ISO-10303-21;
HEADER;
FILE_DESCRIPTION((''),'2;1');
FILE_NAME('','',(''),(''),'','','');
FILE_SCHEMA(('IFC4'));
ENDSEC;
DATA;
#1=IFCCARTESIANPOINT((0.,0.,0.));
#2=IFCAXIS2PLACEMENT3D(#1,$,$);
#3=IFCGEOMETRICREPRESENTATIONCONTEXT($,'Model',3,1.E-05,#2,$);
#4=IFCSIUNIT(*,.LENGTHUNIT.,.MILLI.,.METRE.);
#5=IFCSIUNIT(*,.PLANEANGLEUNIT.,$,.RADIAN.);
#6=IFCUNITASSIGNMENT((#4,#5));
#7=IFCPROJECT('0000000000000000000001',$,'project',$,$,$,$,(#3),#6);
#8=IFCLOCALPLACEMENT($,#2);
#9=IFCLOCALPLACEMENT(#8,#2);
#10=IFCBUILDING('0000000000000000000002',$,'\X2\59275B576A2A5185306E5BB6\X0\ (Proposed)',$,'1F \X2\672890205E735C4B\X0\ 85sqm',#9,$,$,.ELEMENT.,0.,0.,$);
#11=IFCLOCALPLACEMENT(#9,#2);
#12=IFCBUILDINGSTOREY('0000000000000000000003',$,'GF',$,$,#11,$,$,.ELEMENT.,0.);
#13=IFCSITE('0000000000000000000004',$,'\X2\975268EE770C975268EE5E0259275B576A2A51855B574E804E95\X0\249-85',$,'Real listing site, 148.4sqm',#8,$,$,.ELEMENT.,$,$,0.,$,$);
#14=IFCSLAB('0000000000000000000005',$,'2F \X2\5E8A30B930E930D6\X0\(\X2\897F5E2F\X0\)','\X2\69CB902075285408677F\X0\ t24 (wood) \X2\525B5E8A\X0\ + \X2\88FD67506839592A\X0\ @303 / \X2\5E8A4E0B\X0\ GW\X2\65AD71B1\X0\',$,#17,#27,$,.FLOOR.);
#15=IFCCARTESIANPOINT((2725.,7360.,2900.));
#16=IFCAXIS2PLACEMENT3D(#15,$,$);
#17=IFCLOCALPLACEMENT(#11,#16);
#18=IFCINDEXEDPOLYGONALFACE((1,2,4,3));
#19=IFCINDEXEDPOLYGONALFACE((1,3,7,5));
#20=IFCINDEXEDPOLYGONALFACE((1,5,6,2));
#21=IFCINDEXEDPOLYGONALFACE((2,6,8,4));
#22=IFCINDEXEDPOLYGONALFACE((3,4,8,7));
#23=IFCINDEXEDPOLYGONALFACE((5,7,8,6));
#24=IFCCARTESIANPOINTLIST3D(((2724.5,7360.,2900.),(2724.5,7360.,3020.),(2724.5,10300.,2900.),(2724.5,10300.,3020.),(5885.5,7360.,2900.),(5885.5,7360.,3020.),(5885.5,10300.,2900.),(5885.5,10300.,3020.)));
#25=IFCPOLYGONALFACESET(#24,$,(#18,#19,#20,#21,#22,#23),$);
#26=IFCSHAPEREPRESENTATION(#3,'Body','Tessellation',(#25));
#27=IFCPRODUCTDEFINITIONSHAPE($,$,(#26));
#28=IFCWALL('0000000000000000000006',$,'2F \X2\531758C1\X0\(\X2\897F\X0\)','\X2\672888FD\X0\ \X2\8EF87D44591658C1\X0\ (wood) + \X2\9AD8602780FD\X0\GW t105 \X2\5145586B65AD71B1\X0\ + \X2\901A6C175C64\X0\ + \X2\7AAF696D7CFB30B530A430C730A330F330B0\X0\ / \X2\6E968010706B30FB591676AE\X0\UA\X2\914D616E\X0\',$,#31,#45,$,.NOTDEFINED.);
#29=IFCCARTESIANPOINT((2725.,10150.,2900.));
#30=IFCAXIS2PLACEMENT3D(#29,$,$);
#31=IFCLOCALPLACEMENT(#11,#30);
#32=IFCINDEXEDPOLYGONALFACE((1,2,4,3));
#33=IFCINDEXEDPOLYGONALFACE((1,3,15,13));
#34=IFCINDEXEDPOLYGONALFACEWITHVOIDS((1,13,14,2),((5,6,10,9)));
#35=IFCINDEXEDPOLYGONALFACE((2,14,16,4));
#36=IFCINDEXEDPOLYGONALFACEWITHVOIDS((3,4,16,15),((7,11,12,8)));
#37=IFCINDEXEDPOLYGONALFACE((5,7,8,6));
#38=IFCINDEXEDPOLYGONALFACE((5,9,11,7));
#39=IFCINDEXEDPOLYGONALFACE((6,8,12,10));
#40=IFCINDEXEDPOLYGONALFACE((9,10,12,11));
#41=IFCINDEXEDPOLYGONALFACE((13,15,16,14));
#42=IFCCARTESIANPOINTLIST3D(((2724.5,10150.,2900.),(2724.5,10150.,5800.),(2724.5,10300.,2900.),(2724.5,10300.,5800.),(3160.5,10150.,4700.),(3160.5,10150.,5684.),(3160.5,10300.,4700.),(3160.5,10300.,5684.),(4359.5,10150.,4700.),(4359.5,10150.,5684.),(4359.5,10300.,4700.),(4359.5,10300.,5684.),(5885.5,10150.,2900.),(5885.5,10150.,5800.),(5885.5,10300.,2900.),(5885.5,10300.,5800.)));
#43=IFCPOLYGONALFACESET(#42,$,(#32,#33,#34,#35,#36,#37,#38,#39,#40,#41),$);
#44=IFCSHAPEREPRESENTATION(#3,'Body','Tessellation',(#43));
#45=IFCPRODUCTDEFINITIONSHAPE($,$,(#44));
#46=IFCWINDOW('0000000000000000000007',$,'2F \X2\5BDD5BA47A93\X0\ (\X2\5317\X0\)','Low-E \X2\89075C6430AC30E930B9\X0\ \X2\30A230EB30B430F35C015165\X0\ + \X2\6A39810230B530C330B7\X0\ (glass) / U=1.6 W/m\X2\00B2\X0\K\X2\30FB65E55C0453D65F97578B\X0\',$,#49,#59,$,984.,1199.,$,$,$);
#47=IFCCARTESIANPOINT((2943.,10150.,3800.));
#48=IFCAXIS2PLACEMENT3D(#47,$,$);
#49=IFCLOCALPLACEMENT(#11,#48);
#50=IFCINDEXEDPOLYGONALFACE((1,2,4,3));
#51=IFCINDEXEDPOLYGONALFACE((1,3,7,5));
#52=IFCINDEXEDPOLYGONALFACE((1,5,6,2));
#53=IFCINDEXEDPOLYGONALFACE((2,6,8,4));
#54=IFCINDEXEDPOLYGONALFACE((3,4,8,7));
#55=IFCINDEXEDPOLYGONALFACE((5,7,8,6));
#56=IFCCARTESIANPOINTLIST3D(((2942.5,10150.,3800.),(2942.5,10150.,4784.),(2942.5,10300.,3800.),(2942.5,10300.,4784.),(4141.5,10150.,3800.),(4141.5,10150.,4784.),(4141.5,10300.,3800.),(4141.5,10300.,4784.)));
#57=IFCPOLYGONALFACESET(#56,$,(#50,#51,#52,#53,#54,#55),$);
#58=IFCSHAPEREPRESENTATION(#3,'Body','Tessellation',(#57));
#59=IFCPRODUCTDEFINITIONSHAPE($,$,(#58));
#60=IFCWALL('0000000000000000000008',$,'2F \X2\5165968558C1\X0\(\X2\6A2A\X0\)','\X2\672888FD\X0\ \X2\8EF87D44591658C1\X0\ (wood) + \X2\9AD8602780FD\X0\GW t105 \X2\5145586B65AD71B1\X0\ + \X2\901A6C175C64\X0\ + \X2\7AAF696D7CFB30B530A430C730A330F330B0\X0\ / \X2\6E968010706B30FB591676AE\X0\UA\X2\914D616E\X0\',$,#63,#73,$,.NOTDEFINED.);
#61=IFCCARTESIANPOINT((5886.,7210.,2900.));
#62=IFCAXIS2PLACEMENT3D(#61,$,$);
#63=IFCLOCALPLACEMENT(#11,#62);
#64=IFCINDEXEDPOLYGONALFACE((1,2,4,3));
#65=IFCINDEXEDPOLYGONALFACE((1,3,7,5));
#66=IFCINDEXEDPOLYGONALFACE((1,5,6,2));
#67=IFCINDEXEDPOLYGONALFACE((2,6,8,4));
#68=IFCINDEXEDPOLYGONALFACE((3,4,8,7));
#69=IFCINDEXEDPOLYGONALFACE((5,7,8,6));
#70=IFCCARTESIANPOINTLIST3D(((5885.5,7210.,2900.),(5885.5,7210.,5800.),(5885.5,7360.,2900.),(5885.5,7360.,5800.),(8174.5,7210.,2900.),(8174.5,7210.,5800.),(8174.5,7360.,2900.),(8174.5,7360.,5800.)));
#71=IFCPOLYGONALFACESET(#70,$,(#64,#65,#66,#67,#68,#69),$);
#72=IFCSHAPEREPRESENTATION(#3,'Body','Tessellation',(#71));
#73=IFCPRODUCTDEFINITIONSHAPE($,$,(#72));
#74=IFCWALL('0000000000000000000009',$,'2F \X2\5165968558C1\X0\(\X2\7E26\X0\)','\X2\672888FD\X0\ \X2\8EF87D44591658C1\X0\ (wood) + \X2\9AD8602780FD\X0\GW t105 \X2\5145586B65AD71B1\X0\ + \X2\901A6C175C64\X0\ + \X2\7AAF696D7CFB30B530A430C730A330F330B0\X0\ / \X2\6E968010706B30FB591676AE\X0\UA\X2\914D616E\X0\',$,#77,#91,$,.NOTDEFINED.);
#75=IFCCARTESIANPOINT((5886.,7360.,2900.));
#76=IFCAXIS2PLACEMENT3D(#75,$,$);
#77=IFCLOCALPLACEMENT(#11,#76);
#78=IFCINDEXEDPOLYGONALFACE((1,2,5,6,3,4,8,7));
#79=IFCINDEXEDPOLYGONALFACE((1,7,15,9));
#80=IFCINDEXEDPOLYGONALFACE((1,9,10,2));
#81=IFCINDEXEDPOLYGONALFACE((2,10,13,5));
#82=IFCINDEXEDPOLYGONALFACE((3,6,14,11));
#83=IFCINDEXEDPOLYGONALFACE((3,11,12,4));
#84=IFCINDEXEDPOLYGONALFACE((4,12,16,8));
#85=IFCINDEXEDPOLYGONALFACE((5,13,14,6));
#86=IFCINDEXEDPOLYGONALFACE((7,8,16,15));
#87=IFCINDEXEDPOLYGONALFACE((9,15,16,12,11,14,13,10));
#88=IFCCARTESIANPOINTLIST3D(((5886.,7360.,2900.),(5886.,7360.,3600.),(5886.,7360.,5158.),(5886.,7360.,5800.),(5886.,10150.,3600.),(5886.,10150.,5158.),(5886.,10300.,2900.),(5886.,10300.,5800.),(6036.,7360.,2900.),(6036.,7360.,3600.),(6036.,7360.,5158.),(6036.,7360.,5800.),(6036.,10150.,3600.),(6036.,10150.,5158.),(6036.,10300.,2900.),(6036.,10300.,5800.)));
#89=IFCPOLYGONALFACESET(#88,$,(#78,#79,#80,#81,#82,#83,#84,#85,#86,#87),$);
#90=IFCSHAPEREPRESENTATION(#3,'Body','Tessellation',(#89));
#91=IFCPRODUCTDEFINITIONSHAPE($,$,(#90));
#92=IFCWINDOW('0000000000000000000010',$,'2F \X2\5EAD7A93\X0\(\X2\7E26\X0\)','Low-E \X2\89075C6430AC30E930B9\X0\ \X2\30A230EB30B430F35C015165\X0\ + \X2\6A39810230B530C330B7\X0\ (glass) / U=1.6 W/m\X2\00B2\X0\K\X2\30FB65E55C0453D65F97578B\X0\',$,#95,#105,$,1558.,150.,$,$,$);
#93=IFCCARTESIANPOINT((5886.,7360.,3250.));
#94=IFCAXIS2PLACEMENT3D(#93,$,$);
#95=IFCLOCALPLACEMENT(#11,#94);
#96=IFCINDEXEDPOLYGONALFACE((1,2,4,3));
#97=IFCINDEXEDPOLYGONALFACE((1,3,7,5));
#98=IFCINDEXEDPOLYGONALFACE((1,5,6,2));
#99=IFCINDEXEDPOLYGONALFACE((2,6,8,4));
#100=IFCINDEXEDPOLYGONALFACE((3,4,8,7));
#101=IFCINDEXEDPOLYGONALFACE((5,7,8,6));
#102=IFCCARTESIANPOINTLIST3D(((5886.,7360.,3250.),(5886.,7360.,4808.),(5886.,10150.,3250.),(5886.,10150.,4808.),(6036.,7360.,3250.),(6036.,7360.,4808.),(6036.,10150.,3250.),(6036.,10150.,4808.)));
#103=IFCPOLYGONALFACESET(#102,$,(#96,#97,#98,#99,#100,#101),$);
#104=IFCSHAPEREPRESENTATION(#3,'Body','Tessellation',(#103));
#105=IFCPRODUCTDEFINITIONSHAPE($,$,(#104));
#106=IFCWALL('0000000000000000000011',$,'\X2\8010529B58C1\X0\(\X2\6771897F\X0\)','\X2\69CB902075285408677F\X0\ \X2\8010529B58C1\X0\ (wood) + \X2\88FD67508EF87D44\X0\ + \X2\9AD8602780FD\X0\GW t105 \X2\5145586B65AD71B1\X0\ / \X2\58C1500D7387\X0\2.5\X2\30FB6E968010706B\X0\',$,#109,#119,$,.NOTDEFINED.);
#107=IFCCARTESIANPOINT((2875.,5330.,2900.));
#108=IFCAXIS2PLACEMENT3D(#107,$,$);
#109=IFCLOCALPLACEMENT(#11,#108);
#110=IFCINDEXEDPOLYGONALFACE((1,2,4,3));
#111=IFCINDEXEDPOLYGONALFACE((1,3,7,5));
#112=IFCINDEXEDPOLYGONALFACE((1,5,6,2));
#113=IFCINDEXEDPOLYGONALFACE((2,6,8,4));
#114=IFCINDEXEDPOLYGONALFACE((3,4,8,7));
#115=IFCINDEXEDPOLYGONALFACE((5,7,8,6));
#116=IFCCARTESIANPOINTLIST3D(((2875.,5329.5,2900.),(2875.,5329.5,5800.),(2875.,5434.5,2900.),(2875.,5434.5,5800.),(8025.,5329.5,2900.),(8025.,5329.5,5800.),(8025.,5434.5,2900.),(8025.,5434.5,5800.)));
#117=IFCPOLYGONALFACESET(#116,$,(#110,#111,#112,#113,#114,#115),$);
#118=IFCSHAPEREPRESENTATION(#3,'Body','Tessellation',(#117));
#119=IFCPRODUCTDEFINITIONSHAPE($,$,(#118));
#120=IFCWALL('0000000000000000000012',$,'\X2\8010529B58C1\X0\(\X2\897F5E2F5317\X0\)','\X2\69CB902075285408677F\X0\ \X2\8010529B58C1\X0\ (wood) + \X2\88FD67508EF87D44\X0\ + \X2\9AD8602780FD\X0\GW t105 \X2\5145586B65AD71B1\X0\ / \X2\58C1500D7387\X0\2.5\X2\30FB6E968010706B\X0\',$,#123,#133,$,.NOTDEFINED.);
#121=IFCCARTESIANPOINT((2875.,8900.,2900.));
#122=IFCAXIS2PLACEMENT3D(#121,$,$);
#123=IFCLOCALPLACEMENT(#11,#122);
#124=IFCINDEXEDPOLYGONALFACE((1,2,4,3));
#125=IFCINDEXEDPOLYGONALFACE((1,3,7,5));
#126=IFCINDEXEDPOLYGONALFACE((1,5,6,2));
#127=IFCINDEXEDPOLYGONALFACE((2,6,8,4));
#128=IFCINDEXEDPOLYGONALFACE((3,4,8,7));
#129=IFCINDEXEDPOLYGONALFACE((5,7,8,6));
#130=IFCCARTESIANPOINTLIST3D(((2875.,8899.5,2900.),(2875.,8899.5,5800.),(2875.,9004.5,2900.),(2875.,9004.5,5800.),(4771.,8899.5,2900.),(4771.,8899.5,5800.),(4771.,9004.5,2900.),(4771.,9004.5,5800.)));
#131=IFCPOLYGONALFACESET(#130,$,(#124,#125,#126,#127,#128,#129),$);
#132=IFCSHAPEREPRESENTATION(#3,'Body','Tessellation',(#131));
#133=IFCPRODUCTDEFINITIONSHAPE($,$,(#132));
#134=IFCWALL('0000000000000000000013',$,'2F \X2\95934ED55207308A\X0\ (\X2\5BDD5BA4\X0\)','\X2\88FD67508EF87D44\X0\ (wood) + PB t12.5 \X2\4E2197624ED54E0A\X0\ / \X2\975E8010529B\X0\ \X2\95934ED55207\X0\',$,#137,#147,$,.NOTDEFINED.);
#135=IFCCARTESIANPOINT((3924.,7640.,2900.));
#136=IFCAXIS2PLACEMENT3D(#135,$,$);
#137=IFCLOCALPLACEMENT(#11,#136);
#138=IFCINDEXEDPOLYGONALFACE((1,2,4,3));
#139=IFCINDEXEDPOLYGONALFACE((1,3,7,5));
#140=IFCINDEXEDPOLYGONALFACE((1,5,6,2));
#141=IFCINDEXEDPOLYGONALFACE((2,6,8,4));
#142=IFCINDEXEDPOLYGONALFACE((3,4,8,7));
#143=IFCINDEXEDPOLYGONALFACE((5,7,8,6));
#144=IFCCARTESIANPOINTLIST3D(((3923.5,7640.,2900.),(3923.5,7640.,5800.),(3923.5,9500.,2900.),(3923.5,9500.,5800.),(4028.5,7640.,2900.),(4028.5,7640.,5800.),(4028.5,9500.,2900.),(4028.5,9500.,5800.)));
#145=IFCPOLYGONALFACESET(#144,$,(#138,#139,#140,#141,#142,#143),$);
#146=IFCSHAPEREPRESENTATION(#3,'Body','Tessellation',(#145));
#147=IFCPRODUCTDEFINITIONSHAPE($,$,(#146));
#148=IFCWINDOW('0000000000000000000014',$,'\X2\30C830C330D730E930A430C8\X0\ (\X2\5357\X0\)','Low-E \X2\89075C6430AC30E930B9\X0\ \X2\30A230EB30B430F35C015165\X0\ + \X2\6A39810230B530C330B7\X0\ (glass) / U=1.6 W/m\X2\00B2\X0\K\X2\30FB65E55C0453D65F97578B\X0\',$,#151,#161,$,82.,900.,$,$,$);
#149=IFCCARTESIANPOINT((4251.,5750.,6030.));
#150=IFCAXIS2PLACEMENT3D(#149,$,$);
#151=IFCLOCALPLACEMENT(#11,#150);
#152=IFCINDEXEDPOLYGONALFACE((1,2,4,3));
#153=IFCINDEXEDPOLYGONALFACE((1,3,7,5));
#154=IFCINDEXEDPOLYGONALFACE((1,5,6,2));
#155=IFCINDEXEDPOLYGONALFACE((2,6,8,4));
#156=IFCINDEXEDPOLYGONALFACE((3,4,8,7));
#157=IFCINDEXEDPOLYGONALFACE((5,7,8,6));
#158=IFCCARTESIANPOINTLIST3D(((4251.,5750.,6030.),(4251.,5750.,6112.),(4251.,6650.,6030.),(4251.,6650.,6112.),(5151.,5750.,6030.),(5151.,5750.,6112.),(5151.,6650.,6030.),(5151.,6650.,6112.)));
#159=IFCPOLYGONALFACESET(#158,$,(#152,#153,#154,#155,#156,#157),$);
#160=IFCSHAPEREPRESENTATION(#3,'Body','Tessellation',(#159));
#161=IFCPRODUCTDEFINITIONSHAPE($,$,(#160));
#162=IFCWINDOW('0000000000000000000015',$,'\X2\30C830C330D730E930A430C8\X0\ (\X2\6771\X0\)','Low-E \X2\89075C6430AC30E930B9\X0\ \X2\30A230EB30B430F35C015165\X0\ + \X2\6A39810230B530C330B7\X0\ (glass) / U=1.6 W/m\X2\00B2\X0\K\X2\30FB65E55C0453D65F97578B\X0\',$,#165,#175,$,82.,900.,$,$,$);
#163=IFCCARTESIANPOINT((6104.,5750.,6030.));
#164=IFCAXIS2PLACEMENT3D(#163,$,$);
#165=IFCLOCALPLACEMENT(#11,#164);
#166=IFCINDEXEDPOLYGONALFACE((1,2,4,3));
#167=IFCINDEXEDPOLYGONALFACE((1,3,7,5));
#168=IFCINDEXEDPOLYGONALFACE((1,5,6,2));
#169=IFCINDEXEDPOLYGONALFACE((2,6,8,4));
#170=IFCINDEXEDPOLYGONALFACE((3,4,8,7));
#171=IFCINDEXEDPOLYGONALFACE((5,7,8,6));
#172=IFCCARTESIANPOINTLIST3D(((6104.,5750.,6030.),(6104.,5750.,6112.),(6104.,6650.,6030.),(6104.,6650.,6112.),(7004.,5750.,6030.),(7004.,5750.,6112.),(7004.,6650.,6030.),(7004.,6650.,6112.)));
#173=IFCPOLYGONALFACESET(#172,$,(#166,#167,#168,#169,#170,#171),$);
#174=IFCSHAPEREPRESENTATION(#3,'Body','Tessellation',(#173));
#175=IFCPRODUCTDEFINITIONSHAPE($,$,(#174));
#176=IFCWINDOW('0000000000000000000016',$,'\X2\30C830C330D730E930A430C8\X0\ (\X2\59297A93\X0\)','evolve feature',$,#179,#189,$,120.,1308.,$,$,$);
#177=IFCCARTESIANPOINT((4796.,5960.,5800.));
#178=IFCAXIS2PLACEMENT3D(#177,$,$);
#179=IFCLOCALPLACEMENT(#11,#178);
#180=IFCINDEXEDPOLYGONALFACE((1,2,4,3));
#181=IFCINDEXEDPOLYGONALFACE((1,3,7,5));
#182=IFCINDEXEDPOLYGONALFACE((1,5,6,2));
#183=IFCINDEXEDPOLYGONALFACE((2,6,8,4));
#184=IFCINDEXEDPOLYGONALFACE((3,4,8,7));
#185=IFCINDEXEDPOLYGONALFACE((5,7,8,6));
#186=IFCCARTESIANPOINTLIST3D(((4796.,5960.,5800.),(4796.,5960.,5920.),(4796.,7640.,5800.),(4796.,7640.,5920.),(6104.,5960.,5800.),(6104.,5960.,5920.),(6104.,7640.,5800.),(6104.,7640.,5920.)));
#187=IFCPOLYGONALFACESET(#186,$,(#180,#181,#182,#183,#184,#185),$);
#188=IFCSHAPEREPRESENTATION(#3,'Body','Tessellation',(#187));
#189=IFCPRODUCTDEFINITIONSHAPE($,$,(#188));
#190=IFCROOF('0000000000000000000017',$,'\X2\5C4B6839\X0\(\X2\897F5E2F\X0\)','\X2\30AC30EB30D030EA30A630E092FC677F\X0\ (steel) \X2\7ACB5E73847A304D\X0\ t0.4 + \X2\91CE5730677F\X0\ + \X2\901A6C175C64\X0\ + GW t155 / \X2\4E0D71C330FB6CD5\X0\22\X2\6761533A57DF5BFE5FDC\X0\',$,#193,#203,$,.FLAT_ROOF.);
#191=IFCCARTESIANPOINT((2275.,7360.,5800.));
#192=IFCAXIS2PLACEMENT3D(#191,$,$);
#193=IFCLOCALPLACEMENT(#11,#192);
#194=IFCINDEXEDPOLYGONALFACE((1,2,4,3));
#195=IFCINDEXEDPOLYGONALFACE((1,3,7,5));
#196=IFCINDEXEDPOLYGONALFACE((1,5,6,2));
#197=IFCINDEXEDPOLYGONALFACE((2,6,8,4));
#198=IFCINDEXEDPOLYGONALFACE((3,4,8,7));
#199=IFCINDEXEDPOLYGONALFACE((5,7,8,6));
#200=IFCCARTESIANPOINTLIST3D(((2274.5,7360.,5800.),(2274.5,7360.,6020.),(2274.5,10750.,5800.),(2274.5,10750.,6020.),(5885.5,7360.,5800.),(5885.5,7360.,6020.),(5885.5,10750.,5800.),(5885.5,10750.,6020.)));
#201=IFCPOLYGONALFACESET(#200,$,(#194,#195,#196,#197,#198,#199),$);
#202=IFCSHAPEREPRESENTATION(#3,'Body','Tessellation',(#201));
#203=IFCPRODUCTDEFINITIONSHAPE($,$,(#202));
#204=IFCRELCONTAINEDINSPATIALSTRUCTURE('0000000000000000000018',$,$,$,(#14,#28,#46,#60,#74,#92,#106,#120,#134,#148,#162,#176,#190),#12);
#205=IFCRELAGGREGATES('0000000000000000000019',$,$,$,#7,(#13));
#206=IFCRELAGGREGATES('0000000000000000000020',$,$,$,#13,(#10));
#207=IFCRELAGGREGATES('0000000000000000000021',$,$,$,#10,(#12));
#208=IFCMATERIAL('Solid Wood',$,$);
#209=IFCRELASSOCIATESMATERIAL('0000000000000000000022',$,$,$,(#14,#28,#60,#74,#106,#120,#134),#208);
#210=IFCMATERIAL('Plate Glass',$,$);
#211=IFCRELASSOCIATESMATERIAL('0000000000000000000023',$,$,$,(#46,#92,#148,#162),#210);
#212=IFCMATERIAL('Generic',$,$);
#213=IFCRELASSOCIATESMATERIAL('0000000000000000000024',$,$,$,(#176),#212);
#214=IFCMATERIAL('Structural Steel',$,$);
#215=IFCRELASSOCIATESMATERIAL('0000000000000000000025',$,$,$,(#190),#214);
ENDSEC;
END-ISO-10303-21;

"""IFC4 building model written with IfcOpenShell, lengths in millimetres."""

from ifc_helpers import new_model, si_unit, frame, frame_2d, origin, place, context, project, spatial, rectangle, extrude, material, element, fill, save


model = new_model("IFC4")

# Units and contexts
model_context = context("Model", 3, precision=1e-05, world=origin())
ifc_project = project(units=[si_unit("LENGTHUNIT", "METRE", prefix="MILLI"), si_unit("PLANEANGLEUNIT", "RADIAN")], contexts=[model_context])

# Site, building, storey
site_placement = place(None, origin())
site = spatial("IfcSite", under=ifc_project, at=site_placement, Name="青森県青森市大字横内字亀井249-85", ObjectType="Real listing site, 148.4sqm", CompositionType="ELEMENT", RefElevation=0.0)
building_placement = place(site_placement, origin())
building = spatial("IfcBuilding", under=site, at=building_placement, Name="大字横内の家 (Proposed)", ObjectType="1F 木造平屋 85sqm", CompositionType="ELEMENT", ElevationOfRefHeight=0.0, ElevationOfTerrain=0.0)
storey_placement = place(building_placement, origin())
storey = spatial("IfcBuildingStorey", under=building, at=storey_placement, Name="GF", CompositionType="ELEMENT", Elevation=0.0)

# Slab
ifc_material_1 = material(Name="Solid Wood")
slab_placement = place(storey_placement, frame((2725.0, 7360.0, 2900.0)))
element("IfcSlab", 1, at=slab_placement, inside=storey, material=ifc_material_1, Name="2F 床スラブ(西帯)", Description="構造用合板 t24 (wood) 剛床 + 製材根太 @303 / 床下 GW断熱", PredefinedType="FLOOR", context=model_context, shape_type="SweptSolid", body=[
    extrude(rectangle(XDim=3161.0, YDim=2940.0, at=frame_2d((1580.0, 1470.0))), frame((2725.0, 7360.0, 2900.0)), (0.0, 0.0, 1.0), 120.0),
])

# Wall, opening, window
wall_1_placement = place(storey_placement, frame((2725.0, 10150.0, 2900.0)))
wall_1 = element("IfcWall", 2, at=wall_1_placement, inside=storey, material=ifc_material_1, Name="2F 北壁(西)", Description="木製 軸組外壁 (wood) + 高性能GW t105 充填断熱 + 通気層 + 窯業系サイディング / 準耐火・外皮UA配慮", PredefinedType="NOTDEFINED", context=model_context, shape_type="SweptSolid", body=[
    extrude(rectangle(XDim=3161.0, YDim=150.0, at=frame_2d((1580.0, 75.0))), frame((2725.0, 10150.0, 2900.0)), (0.0, 0.0, 1.0), 2900.0),
])
opening_1_placement = place(storey_placement, frame((2943.0, 10150.0, 3800.0)))
opening_1 = element("IfcOpeningElement", 3, at=opening_1_placement, cuts=wall_1, PredefinedType="NOTDEFINED", context=model_context, shape_type="SweptSolid", body=[
    extrude(rectangle(XDim=1199.0, YDim=150.0, at=frame_2d((599.0, 75.0))), frame((2943.0, 10150.0, 3800.0)), (0.0, 0.0, 1.0), 984.0),
])
ifc_material_2 = material(Name="Plate Glass")
window_1_placement = place(storey_placement, frame((2943.0, 10150.0, 3800.0)))
window_1 = element("IfcWindow", 4, at=window_1_placement, inside=storey, material=ifc_material_2, Name="2F 寝室窓 (北)", Description="Low-E 複層ガラス アルゴン封入 + 樹脂サッシ (glass) / U=1.6 W/m²K・日射取得型", OverallHeight=984.0, OverallWidth=1199.0, context=model_context, shape_type="SweptSolid", body=[
    extrude(rectangle(XDim=1199.0, YDim=150.0, at=frame_2d((599.0, 75.0))), frame((2943.0, 10150.0, 3800.0)), (0.0, 0.0, 1.0), 984.0),
])
fill(opening_1, window_1)

# Wall
wall_2_placement = place(storey_placement, frame((5886.0, 7210.0, 2900.0)))
element("IfcWall", 5, at=wall_2_placement, inside=storey, material=ifc_material_1, Name="2F 入隅壁(横)", Description="木製 軸組外壁 (wood) + 高性能GW t105 充填断熱 + 通気層 + 窯業系サイディング / 準耐火・外皮UA配慮", PredefinedType="NOTDEFINED", context=model_context, shape_type="SweptSolid", body=[
    extrude(rectangle(XDim=2289.0, YDim=150.0, at=frame_2d((1144.0, 75.0))), frame((5886.0, 7210.0, 2900.0)), (0.0, 0.0, 1.0), 2900.0),
])

# Wall, opening, window
wall_3_placement = place(storey_placement, frame((5886.0, 7360.0, 2900.0)))
wall_3 = element("IfcWall", 6, at=wall_3_placement, inside=storey, material=ifc_material_1, Name="2F 入隅壁(縦)", Description="木製 軸組外壁 (wood) + 高性能GW t105 充填断熱 + 通気層 + 窯業系サイディング / 準耐火・外皮UA配慮", PredefinedType="NOTDEFINED", context=model_context, shape_type="SweptSolid", body=[
    extrude(rectangle(XDim=150.0, YDim=2940.0, at=frame_2d((75.0, 1470.0))), frame((5886.0, 7360.0, 2900.0)), (0.0, 0.0, 1.0), 2900.0),
])
opening_2_placement = place(storey_placement, frame((5886.0, 7360.0, 3250.0)))
opening_2 = element("IfcOpeningElement", 7, at=opening_2_placement, cuts=wall_3, PredefinedType="NOTDEFINED", context=model_context, shape_type="SweptSolid", body=[
    extrude(rectangle(XDim=150.0, YDim=2790.0, at=frame_2d((75.0, 1395.0))), frame((5886.0, 7360.0, 3250.0)), (0.0, 0.0, 1.0), 1558.0),
])
window_2_placement = place(storey_placement, frame((5886.0, 7360.0, 3250.0)))
window_2 = element("IfcWindow", 8, at=window_2_placement, inside=storey, material=ifc_material_2, Name="2F 庭窓(縦)", Description="Low-E 複層ガラス アルゴン封入 + 樹脂サッシ (glass) / U=1.6 W/m²K・日射取得型", OverallHeight=1558.0, OverallWidth=150.0, context=model_context, shape_type="SweptSolid", body=[
    extrude(rectangle(XDim=150.0, YDim=2790.0, at=frame_2d((75.0, 1395.0))), frame((5886.0, 7360.0, 3250.0)), (0.0, 0.0, 1.0), 1558.0),
])
fill(opening_2, window_2)

# Walls
wall_4_placement = place(storey_placement, frame((2875.0, 5330.0, 2900.0)))
element("IfcWall", 9, at=wall_4_placement, inside=storey, material=ifc_material_1, Name="耐力壁(東西)", Description="構造用合板 耐力壁 (wood) + 製材軸組 + 高性能GW t105 充填断熱 / 壁倍率2.5・準耐火", PredefinedType="NOTDEFINED", context=model_context, shape_type="SweptSolid", body=[
    extrude(rectangle(XDim=5150.0, YDim=105.0, at=frame_2d((2575.0, 52.0))), frame((2875.0, 5330.0, 2900.0)), (0.0, 0.0, 1.0), 2900.0),
])
wall_5_placement = place(storey_placement, frame((2875.0, 8900.0, 2900.0)))
element("IfcWall", 10, at=wall_5_placement, inside=storey, material=ifc_material_1, Name="耐力壁(西帯北)", Description="構造用合板 耐力壁 (wood) + 製材軸組 + 高性能GW t105 充填断熱 / 壁倍率2.5・準耐火", PredefinedType="NOTDEFINED", context=model_context, shape_type="SweptSolid", body=[
    extrude(rectangle(XDim=1896.0, YDim=105.0, at=frame_2d((948.0, 52.0))), frame((2875.0, 8900.0, 2900.0)), (0.0, 0.0, 1.0), 2900.0),
])
wall_6_placement = place(storey_placement, frame((3924.0, 7640.0, 2900.0)))
element("IfcWall", 11, at=wall_6_placement, inside=storey, material=ifc_material_1, Name="2F 間仕切り (寝室)", Description="製材軸組 (wood) + PB t12.5 両面仕上 / 非耐力 間仕切", PredefinedType="NOTDEFINED", context=model_context, shape_type="SweptSolid", body=[
    extrude(rectangle(XDim=105.0, YDim=1860.0, at=frame_2d((52.0, 930.0))), frame((3924.0, 7640.0, 2900.0)), (0.0, 0.0, 1.0), 2900.0),
])

# Windows
window_3_placement = place(storey_placement, frame((4251.0, 5750.0, 6030.0)))
element("IfcWindow", 12, at=window_3_placement, inside=storey, material=ifc_material_2, Name="トップライト (南)", Description="Low-E 複層ガラス アルゴン封入 + 樹脂サッシ (glass) / U=1.6 W/m²K・日射取得型", OverallHeight=82.0, OverallWidth=900.0, context=model_context, shape_type="SweptSolid", body=[
    extrude(rectangle(XDim=900.0, YDim=900.0, at=frame_2d((450.0, 450.0))), frame((4251.0, 5750.0, 6030.0)), (0.0, 0.0, 1.0), 82.0),
])
window_4_placement = place(storey_placement, frame((6104.0, 5750.0, 6030.0)))
element("IfcWindow", 13, at=window_4_placement, inside=storey, material=ifc_material_2, Name="トップライト (東)", Description="Low-E 複層ガラス アルゴン封入 + 樹脂サッシ (glass) / U=1.6 W/m²K・日射取得型", OverallHeight=82.0, OverallWidth=900.0, context=model_context, shape_type="SweptSolid", body=[
    extrude(rectangle(XDim=900.0, YDim=900.0, at=frame_2d((450.0, 450.0))), frame((6104.0, 5750.0, 6030.0)), (0.0, 0.0, 1.0), 82.0),
])
ifc_material_3 = material(Name="Generic")
window_5_placement = place(storey_placement, frame((4796.0, 5960.0, 5800.0)))
element("IfcWindow", 14, at=window_5_placement, inside=storey, material=ifc_material_3, Name="トップライト (天窓)", Description="evolve feature", OverallHeight=120.0, OverallWidth=1308.0, context=model_context, shape_type="SweptSolid", body=[
    extrude(rectangle(XDim=1308.0, YDim=1680.0, at=frame_2d((654.0, 840.0))), frame((4796.0, 5960.0, 5800.0)), (0.0, 0.0, 1.0), 120.0),
])

# Roof
ifc_material_4 = material(Name="Structural Steel")
for number, where, name in (
    (15, (2275.0, 7360.0, 5800.0), "屋根(西帯)"),
):
    element("IfcRoof", number, at=place(storey_placement, frame(where)), inside=storey, material=ifc_material_4, Name=name, Description="ガルバリウム鋼板 (steel) 立平葺き t0.4 + 野地板 + 通気層 + GW t155 / 不燃・法22条区域対応", PredefinedType="FLAT_ROOF", context=model_context, shape_type="SweptSolid", body=[
        extrude(rectangle(XDim=3611.0, YDim=3390.0, at=frame_2d((1805.0, 1695.0))), frame((2275.0, 7360.0, 5800.0)), (0.0, 0.0, 1.0), 220.0),
    ])

save(model, "model.ifc")
